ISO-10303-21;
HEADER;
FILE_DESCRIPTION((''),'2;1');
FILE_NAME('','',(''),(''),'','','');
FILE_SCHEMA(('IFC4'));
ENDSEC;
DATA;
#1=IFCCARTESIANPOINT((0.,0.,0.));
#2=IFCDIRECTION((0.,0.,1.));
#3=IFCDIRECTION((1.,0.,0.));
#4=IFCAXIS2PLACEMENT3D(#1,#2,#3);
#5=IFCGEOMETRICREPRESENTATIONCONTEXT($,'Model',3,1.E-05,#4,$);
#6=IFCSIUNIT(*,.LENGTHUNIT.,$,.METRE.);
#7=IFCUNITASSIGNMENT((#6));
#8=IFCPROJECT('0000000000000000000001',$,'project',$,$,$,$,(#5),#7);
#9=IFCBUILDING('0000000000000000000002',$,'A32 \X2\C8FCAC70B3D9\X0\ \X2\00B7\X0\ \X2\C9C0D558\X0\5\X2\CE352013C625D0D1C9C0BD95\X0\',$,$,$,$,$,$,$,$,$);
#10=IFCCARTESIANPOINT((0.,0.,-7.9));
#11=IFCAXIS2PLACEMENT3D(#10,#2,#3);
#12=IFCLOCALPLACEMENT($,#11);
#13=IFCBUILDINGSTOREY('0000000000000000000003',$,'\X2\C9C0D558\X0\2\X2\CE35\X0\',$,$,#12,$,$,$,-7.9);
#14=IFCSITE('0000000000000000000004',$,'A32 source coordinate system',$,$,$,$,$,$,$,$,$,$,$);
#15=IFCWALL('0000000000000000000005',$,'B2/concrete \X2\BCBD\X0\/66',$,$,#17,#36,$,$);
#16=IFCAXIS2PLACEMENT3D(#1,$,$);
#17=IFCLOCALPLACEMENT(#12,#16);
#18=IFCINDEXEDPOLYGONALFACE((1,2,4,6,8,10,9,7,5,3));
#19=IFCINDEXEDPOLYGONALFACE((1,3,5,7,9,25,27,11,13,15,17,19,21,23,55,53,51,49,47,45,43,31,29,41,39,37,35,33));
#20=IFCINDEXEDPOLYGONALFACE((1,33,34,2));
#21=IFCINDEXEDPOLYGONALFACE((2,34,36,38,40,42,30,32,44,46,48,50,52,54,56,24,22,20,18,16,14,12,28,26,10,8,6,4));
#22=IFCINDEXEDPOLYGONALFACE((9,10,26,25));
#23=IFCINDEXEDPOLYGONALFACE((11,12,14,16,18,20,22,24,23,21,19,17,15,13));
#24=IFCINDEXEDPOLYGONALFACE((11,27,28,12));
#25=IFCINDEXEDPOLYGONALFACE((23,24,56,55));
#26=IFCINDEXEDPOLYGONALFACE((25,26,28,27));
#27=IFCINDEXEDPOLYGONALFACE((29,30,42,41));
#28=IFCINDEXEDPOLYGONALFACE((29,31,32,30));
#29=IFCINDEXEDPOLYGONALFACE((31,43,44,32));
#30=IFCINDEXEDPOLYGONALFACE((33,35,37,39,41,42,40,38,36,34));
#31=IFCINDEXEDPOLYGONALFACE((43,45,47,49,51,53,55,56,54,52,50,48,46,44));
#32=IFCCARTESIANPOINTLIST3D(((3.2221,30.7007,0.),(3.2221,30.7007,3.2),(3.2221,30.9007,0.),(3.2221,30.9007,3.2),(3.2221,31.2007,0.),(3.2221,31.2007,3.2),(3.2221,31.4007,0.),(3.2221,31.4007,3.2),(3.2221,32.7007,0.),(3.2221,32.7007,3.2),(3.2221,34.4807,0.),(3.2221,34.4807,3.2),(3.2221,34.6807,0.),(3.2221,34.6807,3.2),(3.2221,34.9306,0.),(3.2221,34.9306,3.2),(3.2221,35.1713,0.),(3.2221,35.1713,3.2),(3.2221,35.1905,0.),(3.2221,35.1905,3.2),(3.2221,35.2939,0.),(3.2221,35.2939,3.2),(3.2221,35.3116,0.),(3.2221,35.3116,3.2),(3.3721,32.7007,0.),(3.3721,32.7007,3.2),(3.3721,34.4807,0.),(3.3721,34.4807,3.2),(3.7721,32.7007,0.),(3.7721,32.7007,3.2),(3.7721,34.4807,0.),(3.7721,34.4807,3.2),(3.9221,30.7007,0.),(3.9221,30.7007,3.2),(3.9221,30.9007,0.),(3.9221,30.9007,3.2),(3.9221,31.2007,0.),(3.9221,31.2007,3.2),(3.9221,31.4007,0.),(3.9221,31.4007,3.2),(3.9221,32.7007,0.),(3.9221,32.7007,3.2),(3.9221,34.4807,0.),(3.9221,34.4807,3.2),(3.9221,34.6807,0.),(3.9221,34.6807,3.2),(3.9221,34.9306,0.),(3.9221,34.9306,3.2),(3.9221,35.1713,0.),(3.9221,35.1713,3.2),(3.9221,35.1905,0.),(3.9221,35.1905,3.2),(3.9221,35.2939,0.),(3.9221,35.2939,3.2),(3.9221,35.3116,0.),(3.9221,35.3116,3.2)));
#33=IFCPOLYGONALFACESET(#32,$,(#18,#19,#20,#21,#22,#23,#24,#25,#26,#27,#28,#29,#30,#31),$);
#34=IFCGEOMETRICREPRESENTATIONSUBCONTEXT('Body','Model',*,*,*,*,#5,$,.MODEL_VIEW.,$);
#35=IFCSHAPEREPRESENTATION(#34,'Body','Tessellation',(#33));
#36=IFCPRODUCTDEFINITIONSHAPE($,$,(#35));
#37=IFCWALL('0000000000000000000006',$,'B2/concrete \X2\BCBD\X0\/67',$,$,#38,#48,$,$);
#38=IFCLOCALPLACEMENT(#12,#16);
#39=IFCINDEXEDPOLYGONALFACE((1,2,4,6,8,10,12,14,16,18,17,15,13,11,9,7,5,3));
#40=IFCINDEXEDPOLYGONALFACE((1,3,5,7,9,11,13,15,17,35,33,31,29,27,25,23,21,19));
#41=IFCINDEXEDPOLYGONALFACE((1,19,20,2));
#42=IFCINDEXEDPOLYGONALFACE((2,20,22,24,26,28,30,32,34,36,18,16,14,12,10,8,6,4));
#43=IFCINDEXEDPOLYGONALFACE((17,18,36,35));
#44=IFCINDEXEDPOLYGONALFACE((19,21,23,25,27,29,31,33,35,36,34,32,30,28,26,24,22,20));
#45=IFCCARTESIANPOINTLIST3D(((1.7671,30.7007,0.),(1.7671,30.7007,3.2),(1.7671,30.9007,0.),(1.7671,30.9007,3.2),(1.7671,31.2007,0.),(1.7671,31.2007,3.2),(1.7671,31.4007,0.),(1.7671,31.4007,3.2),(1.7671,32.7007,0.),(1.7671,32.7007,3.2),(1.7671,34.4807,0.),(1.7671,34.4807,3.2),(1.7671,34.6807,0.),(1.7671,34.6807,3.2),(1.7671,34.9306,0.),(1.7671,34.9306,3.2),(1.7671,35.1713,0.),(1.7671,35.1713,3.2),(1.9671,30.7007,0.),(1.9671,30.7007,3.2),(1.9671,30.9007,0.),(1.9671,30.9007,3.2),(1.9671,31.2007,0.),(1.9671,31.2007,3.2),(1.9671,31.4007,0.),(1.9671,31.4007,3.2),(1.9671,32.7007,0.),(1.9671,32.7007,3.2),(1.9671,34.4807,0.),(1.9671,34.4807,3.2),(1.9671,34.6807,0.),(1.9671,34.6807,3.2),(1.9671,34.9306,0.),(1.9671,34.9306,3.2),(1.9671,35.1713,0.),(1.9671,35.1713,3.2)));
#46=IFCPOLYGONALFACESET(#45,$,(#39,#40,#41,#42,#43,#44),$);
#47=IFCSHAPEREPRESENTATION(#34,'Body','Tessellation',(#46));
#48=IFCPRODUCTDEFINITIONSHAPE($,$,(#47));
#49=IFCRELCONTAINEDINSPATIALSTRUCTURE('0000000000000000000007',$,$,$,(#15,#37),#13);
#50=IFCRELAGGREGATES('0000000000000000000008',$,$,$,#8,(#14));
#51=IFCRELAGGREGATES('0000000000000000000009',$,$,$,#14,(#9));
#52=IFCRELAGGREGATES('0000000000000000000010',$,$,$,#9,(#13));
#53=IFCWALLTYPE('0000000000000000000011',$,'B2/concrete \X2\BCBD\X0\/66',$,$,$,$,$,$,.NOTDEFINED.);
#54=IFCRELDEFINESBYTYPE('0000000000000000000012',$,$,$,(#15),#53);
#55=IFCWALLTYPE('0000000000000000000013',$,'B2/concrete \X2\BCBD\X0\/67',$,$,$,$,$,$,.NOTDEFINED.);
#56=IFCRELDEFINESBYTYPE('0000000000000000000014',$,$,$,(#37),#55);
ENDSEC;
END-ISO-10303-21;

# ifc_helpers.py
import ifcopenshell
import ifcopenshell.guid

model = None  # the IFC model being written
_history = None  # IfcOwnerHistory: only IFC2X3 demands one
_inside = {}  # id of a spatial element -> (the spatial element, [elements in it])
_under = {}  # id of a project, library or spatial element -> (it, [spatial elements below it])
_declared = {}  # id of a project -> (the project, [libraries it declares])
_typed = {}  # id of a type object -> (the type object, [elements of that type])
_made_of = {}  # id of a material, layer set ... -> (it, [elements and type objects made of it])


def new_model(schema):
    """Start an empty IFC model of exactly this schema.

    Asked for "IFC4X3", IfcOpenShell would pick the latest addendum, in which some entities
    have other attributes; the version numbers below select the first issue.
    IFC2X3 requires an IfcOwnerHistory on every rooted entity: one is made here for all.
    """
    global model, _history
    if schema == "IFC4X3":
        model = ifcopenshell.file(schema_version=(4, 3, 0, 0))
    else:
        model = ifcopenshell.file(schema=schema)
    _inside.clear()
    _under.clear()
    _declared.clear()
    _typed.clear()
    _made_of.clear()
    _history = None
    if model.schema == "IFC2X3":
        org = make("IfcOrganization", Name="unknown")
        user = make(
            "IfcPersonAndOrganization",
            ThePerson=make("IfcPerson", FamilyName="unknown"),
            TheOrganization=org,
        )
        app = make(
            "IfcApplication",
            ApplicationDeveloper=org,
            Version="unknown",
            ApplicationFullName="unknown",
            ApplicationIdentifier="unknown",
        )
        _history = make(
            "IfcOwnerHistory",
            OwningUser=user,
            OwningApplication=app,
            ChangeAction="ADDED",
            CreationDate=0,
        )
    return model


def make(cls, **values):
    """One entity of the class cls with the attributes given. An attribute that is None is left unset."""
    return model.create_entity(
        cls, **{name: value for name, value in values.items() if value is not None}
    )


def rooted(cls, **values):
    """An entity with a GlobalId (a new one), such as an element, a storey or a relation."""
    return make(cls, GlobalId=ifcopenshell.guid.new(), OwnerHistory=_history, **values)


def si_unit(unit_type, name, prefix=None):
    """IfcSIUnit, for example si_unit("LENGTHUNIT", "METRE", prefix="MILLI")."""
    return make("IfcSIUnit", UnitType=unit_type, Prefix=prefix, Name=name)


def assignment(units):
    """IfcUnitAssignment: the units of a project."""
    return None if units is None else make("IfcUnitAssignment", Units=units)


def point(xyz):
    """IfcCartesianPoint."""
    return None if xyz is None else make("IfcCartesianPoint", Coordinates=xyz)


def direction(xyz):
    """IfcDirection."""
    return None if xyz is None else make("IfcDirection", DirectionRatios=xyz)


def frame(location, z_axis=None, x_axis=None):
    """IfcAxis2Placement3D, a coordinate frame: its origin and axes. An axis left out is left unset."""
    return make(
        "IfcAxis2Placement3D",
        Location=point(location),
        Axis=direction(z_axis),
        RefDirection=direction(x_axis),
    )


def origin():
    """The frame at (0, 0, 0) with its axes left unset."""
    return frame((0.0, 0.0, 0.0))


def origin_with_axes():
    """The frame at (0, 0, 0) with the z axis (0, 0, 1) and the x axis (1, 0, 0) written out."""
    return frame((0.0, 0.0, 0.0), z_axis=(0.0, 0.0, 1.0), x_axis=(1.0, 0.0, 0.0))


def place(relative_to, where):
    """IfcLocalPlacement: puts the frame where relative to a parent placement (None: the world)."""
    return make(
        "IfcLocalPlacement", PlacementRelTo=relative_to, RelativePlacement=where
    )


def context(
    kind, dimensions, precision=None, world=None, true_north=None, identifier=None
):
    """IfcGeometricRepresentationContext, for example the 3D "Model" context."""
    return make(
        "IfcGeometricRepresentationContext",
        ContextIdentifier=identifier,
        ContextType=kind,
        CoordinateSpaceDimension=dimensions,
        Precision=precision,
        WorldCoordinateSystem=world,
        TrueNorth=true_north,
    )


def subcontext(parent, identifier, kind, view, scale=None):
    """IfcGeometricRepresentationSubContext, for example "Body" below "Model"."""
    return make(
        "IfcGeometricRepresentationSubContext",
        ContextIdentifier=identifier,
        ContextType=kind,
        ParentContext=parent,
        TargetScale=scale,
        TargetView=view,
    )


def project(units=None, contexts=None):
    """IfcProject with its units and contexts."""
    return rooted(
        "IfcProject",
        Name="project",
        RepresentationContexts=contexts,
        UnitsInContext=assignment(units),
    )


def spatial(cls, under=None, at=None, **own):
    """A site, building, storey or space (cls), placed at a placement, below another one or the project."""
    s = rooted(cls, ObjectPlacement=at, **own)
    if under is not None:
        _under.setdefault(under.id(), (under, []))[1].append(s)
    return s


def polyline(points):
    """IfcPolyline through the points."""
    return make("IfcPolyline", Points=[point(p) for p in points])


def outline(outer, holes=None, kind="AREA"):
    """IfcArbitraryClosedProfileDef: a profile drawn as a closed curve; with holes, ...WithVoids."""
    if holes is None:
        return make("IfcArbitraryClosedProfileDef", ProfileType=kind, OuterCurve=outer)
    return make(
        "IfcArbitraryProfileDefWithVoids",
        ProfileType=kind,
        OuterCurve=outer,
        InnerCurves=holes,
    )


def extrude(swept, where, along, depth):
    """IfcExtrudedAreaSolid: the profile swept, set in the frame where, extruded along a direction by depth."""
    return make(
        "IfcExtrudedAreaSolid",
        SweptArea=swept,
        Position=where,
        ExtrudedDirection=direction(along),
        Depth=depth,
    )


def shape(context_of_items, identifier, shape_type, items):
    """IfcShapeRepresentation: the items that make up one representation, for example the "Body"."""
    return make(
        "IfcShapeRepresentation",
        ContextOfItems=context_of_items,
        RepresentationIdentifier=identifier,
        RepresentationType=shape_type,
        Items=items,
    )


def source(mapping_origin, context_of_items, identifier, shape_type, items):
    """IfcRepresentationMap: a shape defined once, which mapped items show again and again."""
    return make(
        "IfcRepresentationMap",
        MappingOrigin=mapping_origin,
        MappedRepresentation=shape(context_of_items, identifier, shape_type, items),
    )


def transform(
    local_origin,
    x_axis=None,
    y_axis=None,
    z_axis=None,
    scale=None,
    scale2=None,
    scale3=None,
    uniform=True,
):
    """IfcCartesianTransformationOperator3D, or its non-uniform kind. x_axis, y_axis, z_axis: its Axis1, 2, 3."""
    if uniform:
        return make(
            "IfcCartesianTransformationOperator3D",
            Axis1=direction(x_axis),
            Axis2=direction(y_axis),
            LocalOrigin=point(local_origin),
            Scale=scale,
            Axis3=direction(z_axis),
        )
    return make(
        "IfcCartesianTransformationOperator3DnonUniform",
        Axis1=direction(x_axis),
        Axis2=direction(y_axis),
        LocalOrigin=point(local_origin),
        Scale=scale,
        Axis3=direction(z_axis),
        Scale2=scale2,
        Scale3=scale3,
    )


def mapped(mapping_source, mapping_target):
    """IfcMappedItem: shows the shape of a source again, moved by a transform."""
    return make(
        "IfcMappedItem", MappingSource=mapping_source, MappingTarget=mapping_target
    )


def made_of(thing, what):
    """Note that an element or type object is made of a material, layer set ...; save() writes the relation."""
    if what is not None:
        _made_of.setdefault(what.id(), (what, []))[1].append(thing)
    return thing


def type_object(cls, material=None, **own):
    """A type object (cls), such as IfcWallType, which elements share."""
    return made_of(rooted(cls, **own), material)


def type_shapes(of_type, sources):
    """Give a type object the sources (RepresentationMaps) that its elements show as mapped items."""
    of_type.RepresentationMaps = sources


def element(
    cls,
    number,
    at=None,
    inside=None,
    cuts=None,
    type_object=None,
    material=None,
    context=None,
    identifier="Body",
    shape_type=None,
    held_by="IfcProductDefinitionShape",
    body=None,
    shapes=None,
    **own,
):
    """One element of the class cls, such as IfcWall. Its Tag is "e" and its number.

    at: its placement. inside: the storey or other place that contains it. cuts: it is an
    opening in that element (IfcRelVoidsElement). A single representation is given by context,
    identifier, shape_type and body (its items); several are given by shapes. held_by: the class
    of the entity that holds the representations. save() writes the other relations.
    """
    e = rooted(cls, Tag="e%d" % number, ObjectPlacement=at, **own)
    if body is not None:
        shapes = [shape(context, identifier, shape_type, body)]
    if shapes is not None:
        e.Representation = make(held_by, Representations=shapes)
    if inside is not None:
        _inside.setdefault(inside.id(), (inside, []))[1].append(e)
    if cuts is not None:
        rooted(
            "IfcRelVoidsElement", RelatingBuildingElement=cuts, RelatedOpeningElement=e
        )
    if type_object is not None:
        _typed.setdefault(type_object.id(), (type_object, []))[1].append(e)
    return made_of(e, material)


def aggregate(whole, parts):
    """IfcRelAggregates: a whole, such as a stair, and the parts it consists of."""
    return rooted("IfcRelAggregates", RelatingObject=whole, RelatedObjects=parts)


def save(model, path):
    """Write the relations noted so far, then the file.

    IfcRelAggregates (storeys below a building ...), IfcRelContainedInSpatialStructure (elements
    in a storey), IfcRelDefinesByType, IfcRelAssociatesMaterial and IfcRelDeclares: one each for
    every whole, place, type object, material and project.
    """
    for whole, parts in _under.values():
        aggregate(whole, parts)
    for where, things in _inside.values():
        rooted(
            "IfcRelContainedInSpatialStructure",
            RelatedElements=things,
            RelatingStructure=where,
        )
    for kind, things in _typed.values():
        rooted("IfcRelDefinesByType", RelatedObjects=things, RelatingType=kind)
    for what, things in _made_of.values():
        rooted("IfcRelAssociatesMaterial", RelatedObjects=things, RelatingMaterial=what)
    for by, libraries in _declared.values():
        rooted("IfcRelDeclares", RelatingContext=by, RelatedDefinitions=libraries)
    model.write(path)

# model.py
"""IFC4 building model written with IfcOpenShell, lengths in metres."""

from ifc_helpers import new_model, si_unit, frame, origin, origin_with_axes, place, context, subcontext, project, spatial, polyline, outline, extrude, source, transform, mapped, type_object, type_shapes, element, save


model = new_model("IFC4")

# Units and contexts
model_context = context("Model", 3, precision=1e-05, world=origin_with_axes())
body_context = subcontext(model_context, "Body", "Model", "MODEL_VIEW")
ifc_project = project(units=[si_unit("LENGTHUNIT", "METRE")], contexts=[model_context])

# Site, building, storey
site = spatial("IfcSite", under=ifc_project, Name="A32 source coordinate system")
building = spatial("IfcBuilding", under=site, Name="A32 주거동 · 지하5층–옥탑지붕")
storey_placement = place(None, frame((0.0, 0.0, -7.9), z_axis=(0.0, 0.0, 1.0), x_axis=(1.0, 0.0, 0.0)))
storey = spatial("IfcBuildingStorey", under=building, at=storey_placement, Name="지하2층", Elevation=-7.9)

# Walls
wall_type_1 = type_object("IfcWallType", Name="B2/concrete 벽/66", PredefinedType="NOTDEFINED")
shared_shape_1 = source(origin(), body_context, "Body", "SweptSolid", [
    extrude(outline(polyline([(3.3721, 32.7007), (3.3721, 34.4807), (3.2221, 34.4807), (3.2221, 34.6807), (3.2221, 34.9306), (3.2221, 35.1713), (3.2221, 35.1905), (3.2221, 35.2939), (3.2221, 35.3116), (3.9221, 35.3116), (3.9221, 35.2939), (3.9221, 35.1905), (3.9221, 35.1713), (3.9221, 34.9306), (3.9221, 34.6807), (3.9221, 34.4807), (3.7721, 34.4807), (3.7721, 32.7007), (3.9221, 32.7007), (3.9221, 31.4007), (3.9221, 31.2007), (3.9221, 30.9007), (3.9221, 30.7007), (3.2221, 30.7007), (3.2221, 30.9007), (3.2221, 31.2007), (3.2221, 31.4007), (3.2221, 32.7007), (3.3721, 32.7007)])), origin(), (0.0, 0.0, 1.0), 3.2),
])
type_shapes(wall_type_1, [shared_shape_1])
wall_1_placement = place(storey_placement, origin_with_axes())
element("IfcWall", 1, at=wall_1_placement, inside=storey, type_object=wall_type_1, Name="B2/concrete 벽/66", context=body_context, shape_type="MappedRepresentation", body=[
    mapped(shared_shape_1, transform((0.0, 0.0, 0.0), scale=1.0)),
])
wall_type_2 = type_object("IfcWallType", Name="B2/concrete 벽/67", PredefinedType="NOTDEFINED")
shared_shape_2 = source(origin(), body_context, "Body", "SweptSolid", [
    extrude(outline(polyline([(1.7671, 34.4807), (1.7671, 34.6807), (1.7671, 34.9306), (1.7671, 35.1713), (1.9671, 35.1713), (1.9671, 34.9306), (1.9671, 34.6807), (1.9671, 34.4807), (1.9671, 32.7007), (1.9671, 31.4007), (1.9671, 31.2007), (1.9671, 30.9007), (1.9671, 30.7007), (1.7671, 30.7007), (1.7671, 30.9007), (1.7671, 31.2007), (1.7671, 31.4007), (1.7671, 32.7007), (1.7671, 34.4807)])), origin(), (0.0, 0.0, 1.0), 3.2),
])
type_shapes(wall_type_2, [shared_shape_2])
wall_2_placement = place(storey_placement, origin_with_axes())
element("IfcWall", 2, at=wall_2_placement, inside=storey, type_object=wall_type_2, Name="B2/concrete 벽/67", context=body_context, shape_type="MappedRepresentation", body=[
    mapped(shared_shape_2, transform((0.0, 0.0, 0.0), scale=1.0)),
])

save(model, "model.ifc")
